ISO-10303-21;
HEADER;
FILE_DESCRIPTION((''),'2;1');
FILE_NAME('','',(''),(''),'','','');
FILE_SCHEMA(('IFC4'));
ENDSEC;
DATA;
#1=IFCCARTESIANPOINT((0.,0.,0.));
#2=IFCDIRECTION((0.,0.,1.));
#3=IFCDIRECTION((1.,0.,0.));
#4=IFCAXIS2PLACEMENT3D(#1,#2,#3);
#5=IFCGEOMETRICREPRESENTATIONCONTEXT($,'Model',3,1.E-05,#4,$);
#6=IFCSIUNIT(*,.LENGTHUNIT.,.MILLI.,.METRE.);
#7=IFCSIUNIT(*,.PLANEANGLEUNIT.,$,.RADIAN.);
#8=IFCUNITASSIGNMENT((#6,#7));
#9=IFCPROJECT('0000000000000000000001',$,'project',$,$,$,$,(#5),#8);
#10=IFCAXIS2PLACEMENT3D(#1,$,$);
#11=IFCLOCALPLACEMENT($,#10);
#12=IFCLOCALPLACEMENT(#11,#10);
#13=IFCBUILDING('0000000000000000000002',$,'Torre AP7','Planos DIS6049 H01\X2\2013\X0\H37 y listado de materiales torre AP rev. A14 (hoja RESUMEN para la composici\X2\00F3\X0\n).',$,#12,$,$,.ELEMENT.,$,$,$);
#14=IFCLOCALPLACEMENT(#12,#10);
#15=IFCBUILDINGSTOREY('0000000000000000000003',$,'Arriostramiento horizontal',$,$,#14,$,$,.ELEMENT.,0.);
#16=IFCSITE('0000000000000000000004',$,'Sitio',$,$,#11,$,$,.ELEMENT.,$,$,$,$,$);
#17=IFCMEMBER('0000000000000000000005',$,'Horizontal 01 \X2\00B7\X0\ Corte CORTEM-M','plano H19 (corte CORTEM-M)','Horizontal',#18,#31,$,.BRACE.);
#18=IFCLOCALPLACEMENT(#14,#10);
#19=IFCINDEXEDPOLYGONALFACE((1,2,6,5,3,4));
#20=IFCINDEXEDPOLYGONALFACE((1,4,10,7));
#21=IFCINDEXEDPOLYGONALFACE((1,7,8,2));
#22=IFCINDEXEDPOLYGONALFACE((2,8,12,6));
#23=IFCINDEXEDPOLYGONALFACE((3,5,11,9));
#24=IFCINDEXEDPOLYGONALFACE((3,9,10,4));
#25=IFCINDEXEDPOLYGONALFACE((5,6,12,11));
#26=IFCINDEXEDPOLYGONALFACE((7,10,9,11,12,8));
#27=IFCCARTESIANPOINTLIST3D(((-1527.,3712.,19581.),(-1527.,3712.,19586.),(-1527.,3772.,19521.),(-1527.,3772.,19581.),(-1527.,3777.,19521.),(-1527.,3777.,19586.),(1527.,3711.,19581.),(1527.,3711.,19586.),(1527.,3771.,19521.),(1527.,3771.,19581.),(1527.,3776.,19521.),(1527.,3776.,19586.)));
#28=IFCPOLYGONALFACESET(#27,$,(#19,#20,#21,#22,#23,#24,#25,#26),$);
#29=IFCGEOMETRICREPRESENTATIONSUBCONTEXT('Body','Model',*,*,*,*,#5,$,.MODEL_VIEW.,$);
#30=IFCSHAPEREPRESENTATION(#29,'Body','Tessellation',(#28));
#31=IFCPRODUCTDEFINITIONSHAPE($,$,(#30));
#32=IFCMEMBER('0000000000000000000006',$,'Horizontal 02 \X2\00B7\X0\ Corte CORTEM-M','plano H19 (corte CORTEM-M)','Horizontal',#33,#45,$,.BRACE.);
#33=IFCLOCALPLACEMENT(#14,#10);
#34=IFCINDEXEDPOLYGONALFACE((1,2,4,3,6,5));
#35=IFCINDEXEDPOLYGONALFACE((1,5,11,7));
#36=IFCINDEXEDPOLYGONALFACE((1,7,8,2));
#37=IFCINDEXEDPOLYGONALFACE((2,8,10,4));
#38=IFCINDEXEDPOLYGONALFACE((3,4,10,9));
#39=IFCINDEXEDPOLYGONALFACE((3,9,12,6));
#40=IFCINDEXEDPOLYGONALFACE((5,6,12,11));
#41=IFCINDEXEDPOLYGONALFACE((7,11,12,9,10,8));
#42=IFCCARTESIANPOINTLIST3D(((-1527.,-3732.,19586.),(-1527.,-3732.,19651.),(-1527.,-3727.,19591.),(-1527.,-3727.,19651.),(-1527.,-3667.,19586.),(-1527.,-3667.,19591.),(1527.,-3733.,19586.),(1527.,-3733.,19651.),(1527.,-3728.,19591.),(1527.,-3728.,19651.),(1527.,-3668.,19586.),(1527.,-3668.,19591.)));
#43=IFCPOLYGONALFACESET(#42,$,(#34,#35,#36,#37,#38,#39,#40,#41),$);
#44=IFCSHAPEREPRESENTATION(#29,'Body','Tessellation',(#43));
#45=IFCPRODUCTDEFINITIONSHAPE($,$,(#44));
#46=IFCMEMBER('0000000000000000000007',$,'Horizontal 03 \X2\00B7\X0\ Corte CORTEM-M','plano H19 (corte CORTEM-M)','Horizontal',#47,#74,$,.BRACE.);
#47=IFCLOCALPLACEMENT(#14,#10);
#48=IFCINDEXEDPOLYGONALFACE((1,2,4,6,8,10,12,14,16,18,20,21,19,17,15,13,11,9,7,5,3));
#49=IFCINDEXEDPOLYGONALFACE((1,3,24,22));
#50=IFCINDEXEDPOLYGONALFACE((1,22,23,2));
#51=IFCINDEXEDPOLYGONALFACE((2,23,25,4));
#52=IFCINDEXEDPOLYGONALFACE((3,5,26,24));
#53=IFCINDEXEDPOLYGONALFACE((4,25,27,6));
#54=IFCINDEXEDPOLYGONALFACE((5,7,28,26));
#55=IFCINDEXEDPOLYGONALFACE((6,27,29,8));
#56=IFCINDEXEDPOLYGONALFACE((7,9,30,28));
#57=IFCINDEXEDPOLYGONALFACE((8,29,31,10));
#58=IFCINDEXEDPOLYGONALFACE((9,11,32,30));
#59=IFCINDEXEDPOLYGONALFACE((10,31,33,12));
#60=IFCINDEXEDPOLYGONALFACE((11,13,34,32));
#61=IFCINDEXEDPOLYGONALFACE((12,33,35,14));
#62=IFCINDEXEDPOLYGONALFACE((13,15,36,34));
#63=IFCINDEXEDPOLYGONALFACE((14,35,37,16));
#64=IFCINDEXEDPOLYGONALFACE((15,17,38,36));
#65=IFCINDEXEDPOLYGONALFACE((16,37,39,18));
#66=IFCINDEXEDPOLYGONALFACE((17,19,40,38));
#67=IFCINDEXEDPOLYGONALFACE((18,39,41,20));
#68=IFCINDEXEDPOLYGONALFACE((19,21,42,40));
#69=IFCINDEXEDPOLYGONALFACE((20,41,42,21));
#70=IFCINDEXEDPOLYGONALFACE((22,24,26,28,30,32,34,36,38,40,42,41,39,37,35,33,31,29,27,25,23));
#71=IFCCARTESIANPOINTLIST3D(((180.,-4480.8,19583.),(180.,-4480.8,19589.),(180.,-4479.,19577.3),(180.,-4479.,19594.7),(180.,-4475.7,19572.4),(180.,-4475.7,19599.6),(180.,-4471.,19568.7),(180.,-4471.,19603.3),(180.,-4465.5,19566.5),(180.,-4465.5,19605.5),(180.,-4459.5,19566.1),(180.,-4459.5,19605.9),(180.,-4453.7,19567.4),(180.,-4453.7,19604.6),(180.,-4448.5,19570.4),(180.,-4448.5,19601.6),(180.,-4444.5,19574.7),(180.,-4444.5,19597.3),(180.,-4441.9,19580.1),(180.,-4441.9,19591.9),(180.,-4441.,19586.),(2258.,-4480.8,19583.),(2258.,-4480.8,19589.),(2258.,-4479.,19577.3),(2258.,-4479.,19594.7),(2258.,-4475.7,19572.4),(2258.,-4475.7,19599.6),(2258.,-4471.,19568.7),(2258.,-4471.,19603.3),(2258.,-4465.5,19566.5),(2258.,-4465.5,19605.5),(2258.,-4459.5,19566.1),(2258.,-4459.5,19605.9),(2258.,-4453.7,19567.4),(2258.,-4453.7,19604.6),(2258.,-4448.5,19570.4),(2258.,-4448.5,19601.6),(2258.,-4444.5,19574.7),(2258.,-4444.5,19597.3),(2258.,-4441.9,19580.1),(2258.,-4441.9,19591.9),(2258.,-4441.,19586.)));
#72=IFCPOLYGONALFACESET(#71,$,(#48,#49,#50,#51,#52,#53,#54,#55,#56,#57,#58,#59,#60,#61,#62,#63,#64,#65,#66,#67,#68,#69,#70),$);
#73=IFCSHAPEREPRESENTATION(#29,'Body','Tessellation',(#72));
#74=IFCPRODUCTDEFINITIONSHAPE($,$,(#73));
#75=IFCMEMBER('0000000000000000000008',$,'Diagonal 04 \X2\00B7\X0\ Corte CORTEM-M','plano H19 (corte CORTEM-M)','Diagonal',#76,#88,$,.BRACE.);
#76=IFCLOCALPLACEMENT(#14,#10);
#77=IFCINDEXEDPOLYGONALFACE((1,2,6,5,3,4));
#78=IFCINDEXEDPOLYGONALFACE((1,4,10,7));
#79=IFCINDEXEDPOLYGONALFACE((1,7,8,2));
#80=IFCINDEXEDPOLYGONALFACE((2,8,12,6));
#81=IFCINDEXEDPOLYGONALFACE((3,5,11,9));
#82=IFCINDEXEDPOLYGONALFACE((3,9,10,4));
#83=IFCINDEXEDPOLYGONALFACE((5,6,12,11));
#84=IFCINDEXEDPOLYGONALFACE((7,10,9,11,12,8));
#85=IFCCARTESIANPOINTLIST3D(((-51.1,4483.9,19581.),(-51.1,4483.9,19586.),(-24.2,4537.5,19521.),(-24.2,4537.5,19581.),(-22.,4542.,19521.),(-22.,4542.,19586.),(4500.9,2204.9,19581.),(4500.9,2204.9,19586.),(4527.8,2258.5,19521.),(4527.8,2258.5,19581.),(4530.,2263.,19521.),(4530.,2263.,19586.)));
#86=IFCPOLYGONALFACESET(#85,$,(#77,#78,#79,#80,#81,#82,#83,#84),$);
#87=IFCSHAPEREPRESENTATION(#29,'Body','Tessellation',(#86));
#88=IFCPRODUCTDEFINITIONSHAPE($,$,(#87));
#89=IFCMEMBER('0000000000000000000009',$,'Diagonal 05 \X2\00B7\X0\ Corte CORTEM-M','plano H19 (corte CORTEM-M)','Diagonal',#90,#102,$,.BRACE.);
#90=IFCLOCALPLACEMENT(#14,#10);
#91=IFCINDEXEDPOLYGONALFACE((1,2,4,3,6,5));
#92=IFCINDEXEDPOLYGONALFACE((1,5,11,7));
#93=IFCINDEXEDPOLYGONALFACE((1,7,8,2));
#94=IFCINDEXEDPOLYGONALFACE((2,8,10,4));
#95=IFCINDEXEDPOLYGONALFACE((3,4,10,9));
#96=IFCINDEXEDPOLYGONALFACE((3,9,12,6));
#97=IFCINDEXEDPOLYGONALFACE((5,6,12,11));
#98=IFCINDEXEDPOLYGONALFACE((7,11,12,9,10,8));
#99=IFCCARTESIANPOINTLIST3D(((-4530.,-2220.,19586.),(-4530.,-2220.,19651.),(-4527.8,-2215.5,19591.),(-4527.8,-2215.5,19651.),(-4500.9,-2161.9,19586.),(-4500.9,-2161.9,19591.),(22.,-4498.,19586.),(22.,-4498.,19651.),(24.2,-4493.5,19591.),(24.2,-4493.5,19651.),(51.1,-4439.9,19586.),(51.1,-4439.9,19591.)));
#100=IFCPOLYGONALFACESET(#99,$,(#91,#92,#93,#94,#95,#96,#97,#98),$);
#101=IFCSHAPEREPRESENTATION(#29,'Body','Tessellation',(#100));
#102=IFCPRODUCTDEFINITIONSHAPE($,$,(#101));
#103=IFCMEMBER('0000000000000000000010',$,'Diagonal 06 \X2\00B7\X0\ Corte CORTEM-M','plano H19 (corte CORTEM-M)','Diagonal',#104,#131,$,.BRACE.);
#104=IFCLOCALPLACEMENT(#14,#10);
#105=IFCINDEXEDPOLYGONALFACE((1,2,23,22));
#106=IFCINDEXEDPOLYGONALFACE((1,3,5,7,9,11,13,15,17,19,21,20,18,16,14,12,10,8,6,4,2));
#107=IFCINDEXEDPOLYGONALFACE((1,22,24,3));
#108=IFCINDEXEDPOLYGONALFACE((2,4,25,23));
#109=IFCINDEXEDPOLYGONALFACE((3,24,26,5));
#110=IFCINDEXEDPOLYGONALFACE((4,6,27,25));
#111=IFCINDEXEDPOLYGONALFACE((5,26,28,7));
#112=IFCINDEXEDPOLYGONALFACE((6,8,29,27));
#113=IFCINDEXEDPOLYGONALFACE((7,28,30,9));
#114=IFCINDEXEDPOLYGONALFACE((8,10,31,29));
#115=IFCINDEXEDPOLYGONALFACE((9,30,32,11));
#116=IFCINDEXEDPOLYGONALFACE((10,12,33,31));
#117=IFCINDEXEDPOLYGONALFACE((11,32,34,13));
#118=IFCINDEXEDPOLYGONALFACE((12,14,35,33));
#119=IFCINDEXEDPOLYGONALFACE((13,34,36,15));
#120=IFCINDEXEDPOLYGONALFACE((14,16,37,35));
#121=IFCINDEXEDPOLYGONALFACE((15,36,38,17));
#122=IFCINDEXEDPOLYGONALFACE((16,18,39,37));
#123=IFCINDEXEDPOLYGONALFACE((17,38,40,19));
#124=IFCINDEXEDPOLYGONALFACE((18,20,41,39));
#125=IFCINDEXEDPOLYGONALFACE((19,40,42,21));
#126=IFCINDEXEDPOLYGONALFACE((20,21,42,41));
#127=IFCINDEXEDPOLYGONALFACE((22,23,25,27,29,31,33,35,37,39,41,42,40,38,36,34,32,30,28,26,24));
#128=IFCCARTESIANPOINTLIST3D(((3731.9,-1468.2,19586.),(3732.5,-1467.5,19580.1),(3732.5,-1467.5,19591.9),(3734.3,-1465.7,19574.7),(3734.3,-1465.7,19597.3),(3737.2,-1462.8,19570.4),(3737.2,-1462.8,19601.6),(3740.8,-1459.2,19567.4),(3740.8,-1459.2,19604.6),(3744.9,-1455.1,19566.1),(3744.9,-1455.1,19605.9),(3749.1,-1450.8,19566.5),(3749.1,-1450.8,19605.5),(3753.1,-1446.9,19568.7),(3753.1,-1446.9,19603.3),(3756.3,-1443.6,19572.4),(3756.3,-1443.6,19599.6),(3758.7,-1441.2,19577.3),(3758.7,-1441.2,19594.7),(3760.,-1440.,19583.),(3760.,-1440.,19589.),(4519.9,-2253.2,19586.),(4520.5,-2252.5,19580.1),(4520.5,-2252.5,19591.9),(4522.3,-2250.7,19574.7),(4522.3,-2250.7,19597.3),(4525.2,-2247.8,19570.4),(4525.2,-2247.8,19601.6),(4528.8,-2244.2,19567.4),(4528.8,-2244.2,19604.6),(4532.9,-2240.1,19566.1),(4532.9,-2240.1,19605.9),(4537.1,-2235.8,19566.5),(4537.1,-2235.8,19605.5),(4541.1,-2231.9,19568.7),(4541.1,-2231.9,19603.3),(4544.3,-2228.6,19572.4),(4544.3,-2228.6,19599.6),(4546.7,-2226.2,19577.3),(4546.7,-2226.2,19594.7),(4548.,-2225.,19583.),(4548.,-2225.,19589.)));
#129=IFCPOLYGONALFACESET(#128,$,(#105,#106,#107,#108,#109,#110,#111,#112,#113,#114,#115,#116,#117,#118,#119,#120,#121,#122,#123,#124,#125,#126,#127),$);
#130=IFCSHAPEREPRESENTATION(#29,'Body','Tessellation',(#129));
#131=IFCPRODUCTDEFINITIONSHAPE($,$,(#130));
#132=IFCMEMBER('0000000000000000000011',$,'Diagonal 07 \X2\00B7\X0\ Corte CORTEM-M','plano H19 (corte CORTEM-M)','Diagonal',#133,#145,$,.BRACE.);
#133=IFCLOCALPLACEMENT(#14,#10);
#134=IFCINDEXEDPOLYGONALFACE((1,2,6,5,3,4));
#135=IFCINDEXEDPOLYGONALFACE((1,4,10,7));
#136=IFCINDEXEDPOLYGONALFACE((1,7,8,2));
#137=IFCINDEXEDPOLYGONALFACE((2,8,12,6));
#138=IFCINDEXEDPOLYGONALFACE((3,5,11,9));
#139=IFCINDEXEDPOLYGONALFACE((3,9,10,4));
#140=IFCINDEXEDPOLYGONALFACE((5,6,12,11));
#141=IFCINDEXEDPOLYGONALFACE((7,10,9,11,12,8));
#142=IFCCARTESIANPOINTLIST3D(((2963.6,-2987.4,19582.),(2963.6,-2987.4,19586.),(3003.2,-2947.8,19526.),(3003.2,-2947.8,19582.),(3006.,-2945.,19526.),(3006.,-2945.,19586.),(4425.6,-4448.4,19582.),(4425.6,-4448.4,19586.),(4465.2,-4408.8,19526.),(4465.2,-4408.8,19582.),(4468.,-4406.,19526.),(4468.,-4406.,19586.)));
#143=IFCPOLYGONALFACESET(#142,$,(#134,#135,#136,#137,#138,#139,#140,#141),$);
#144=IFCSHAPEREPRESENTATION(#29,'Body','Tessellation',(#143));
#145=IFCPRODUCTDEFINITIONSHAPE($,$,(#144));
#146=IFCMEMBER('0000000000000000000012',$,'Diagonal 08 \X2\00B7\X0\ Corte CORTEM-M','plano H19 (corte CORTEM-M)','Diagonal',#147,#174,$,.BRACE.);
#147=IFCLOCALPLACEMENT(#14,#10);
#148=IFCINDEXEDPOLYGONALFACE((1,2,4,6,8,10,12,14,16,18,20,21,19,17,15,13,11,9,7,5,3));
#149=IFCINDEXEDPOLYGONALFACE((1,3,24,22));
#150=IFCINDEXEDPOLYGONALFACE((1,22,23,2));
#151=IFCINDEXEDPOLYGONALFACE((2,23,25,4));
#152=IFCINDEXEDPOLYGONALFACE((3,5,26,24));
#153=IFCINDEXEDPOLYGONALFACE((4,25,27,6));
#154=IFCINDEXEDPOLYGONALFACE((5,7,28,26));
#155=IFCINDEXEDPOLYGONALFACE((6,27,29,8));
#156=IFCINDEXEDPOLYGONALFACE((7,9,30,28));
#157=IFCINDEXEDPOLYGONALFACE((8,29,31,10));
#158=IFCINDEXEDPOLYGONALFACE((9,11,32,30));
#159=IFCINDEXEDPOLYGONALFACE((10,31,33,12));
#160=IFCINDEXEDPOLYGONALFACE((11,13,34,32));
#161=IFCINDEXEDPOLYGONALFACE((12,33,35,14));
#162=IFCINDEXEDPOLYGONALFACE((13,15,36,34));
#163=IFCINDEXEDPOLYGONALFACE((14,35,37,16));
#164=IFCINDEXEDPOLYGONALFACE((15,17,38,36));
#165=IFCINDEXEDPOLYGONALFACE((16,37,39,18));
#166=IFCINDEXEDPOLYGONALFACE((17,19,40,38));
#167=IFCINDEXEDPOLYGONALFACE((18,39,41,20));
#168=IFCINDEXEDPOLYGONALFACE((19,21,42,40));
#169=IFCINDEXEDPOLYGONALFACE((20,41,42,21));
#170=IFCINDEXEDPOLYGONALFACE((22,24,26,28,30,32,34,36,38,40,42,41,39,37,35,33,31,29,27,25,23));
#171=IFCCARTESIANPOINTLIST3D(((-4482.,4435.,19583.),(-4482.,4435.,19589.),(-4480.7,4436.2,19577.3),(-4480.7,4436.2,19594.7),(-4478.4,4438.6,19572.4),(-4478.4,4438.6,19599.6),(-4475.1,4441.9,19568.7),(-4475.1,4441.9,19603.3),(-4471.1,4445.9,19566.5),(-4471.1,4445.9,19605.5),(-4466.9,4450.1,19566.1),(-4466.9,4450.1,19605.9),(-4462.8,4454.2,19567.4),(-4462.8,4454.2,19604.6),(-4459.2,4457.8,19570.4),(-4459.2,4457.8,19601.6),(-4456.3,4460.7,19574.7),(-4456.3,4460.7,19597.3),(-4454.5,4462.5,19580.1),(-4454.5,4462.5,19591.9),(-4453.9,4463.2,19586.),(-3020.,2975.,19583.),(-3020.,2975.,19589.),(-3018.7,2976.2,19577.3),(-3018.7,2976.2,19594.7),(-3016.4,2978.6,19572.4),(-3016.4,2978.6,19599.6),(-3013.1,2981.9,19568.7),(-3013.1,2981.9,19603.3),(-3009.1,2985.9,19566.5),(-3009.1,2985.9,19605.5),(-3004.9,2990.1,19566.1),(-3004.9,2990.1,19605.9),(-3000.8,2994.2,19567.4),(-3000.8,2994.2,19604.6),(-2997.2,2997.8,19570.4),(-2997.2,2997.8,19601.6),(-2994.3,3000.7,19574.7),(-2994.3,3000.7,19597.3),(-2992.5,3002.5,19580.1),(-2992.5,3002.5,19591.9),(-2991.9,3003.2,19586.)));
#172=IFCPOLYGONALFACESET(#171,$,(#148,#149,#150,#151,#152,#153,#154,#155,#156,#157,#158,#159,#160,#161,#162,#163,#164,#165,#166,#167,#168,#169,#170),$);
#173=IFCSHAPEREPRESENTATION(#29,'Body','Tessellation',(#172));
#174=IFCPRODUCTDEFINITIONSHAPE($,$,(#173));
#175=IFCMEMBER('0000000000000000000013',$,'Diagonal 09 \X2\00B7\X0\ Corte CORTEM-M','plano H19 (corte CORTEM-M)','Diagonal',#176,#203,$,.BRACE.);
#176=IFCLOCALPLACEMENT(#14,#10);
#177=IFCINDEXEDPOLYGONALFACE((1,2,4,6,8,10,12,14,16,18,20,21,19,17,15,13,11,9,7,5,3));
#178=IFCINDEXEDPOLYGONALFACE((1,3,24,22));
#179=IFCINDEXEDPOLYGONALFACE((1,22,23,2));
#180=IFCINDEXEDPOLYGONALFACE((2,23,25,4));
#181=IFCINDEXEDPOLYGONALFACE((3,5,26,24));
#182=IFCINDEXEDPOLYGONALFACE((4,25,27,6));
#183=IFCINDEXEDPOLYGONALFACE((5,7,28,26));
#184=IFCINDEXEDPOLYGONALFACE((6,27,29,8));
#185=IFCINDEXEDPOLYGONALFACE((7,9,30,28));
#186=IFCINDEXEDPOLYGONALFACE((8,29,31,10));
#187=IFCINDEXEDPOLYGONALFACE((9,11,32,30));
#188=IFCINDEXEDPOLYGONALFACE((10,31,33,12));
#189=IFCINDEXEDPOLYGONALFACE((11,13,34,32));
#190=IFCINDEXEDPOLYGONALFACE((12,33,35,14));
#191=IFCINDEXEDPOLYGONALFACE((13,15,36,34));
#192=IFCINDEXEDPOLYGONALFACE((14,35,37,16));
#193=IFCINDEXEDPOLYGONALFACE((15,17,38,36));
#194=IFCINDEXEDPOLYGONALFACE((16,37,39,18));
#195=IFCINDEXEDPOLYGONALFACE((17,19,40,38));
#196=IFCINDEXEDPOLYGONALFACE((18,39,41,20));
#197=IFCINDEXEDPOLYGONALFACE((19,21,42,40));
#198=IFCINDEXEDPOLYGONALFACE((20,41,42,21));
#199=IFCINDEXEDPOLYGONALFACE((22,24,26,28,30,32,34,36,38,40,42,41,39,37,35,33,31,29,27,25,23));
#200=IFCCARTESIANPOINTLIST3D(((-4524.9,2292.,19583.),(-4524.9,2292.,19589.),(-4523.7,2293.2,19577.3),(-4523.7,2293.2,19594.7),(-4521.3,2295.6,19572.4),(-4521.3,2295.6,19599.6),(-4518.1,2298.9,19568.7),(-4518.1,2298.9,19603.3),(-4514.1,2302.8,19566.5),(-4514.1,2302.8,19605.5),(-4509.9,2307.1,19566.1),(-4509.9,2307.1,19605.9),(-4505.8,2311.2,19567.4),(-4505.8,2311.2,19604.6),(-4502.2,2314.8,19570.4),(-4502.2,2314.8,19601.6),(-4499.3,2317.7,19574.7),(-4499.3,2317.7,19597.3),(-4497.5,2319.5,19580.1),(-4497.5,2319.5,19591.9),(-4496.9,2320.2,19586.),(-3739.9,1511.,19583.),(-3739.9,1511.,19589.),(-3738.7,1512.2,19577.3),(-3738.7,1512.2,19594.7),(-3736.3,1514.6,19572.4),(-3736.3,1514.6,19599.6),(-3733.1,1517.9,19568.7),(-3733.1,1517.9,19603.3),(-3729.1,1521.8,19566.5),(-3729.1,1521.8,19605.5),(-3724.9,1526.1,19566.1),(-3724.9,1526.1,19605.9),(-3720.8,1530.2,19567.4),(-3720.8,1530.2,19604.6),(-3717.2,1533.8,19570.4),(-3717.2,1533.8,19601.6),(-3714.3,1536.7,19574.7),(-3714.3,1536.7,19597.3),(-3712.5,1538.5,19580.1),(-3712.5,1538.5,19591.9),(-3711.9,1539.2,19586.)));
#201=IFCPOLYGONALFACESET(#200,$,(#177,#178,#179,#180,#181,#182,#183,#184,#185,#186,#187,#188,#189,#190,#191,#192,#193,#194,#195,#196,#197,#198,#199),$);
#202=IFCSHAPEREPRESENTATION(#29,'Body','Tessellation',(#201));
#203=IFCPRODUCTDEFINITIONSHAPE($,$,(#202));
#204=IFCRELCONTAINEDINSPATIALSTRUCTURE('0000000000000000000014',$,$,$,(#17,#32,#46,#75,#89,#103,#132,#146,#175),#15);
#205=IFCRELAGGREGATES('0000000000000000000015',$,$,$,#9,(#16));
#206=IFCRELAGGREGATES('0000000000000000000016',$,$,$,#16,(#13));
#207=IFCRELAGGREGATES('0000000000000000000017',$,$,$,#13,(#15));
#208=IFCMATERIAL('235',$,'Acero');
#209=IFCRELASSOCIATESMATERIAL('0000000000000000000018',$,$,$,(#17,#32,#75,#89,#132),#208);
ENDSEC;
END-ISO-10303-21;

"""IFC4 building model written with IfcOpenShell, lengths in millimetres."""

from ifc_helpers import new_model, si_unit, frame, frame_2d, origin, origin_with_axes, place, context, subcontext, project, spatial, circle, l_section, extrude, material, element, save


model = new_model("IFC4")

# Units and contexts
model_context = context("Model", 3, precision=1e-05, world=origin_with_axes())
body_context = subcontext(model_context, "Body", "Model", "MODEL_VIEW")
ifc_project = project(units=[si_unit("LENGTHUNIT", "METRE", prefix="MILLI"), si_unit("PLANEANGLEUNIT", "RADIAN")], contexts=[model_context])

# Site, building, storey
site_placement = place(None, origin())
site = spatial("IfcSite", under=ifc_project, at=site_placement, Name="Sitio", CompositionType="ELEMENT")
building_placement = place(site_placement, origin())
building = spatial("IfcBuilding", under=site, at=building_placement, Name="Torre AP7", Description="Planos DIS6049 H01–H37 y listado de materiales torre AP rev. A14 (hoja RESUMEN para la composición).", CompositionType="ELEMENT")
storey_placement = place(building_placement, origin())
storey = spatial("IfcBuildingStorey", under=building, at=storey_placement, Name="Arriostramiento horizontal", CompositionType="ELEMENT", Elevation=0.0)

# Members
ifc_material = material(Name="235", Category="Acero")
for number, where, z_axis, x_axis, name in (
    (1, (-1527.0, 3777.0, 19586.0), (1.0, -0.000327, 0.0), (-0.000327, -1.0, 0.0), "Horizontal 01 · Corte CORTEM-M"),
    (2, (-1527.0, -3732.0, 19586.0), (1.0, -0.000327, 0.0), (0.000327, 1.0, 0.0), "Horizontal 02 · Corte CORTEM-M"),
):
    element("IfcMember", number, at=place(storey_placement, frame(where, z_axis=z_axis, x_axis=x_axis)), inside=storey, material=ifc_material, Name=name, Description="plano H19 (corte CORTEM-M)", ObjectType="Horizontal", PredefinedType="BRACE", context=body_context, shape_type="SweptSolid", body=[
        extrude(l_section(Depth=65.0, Width=65.0, Thickness=5.0, at=frame_2d((32.5, 32.5))), None, (0.0, 0.0, 1.0), 3054.0),
    ])
member_1_placement = place(storey_placement, frame((180.0, -4461.0, 19586.0), z_axis=(1.0, 0.0, 0.0), x_axis=(0.0, 1.0, 0.0)))
element("IfcMember", 3, at=member_1_placement, inside=storey, Name="Horizontal 03 · Corte CORTEM-M", Description="plano H19 (corte CORTEM-M)", ObjectType="Horizontal", PredefinedType="BRACE", context=body_context, shape_type="SweptSolid", body=[
    extrude(circle(Radius=20.0), None, (0.0, 0.0, 1.0), 2078.0),
])
member_2_placement = place(storey_placement, frame((-22.0, 4542.0, 19586.0), z_axis=(0.894191, -0.447685, 0.0), x_axis=(-0.447685, -0.894191, 0.0)))
element("IfcMember", 4, at=member_2_placement, inside=storey, material=ifc_material, Name="Diagonal 04 · Corte CORTEM-M", Description="plano H19 (corte CORTEM-M)", ObjectType="Diagonal", PredefinedType="BRACE", context=body_context, shape_type="SweptSolid", body=[
    extrude(l_section(Depth=65.0, Width=65.0, Thickness=5.0, at=frame_2d((32.5, 32.5))), None, (0.0, 0.0, 1.0), 5090.6),
])
member_3_placement = place(storey_placement, frame((-4530.0, -2220.0, 19586.0), z_axis=(0.89427, -0.447528, 0.0), x_axis=(0.447528, 0.89427, 0.0)))
element("IfcMember", 5, at=member_3_placement, inside=storey, material=ifc_material, Name="Diagonal 05 · Corte CORTEM-M", Description="plano H19 (corte CORTEM-M)", ObjectType="Diagonal", PredefinedType="BRACE", context=body_context, shape_type="SweptSolid", body=[
    extrude(l_section(Depth=65.0, Width=65.0, Thickness=5.0, at=frame_2d((32.5, 32.5))), None, (0.0, 0.0, 1.0), 5090.2),
])
member_4_placement = place(storey_placement, frame((3746.0, -1454.0, 19586.0), z_axis=(0.708454, -0.705757, 0.0), x_axis=(-0.705757, -0.708454, 0.0)))
element("IfcMember", 6, at=member_4_placement, inside=storey, Name="Diagonal 06 · Corte CORTEM-M", Description="plano H19 (corte CORTEM-M)", ObjectType="Diagonal", PredefinedType="BRACE", context=body_context, shape_type="SweptSolid", body=[
    extrude(circle(Radius=20.0), None, (0.0, 0.0, 1.0), 1112.3),
])
member_5_placement = place(storey_placement, frame((3006.0, -2945.0, 19586.0), z_axis=(0.707349, -0.706865, 0.0), x_axis=(-0.706865, -0.707349, 0.0)))
element("IfcMember", 7, at=member_5_placement, inside=storey, material=ifc_material, Name="Diagonal 07 · Corte CORTEM-M", Description="plano H19 (corte CORTEM-M)", ObjectType="Diagonal", PredefinedType="BRACE", context=body_context, shape_type="SweptSolid", body=[
    extrude(l_section(Depth=60.0, Width=60.0, Thickness=4.0, at=frame_2d((30.0, 30.0))), None, (0.0, 0.0, 1.0), 2066.9),
])
member_6_placement = place(storey_placement, frame((-4468.0, 4449.0, 19586.0), z_axis=(0.707591, -0.706623, 0.0), x_axis=(0.706623, 0.707591, 0.0)))
element("IfcMember", 8, at=member_6_placement, inside=storey, Name="Diagonal 08 · Corte CORTEM-M", Description="plano H19 (corte CORTEM-M)", ObjectType="Diagonal", PredefinedType="BRACE", context=body_context, shape_type="SweptSolid", body=[
    extrude(circle(Radius=20.0), None, (0.0, 0.0, 1.0), 2066.2),
])
member_7_placement = place(storey_placement, frame((-4511.0, 2306.0, 19586.0), z_axis=(0.708911, -0.705298, 0.0), x_axis=(0.705298, 0.708911, 0.0)))
element("IfcMember", 9, at=member_7_placement, inside=storey, Name="Diagonal 09 · Corte CORTEM-M", Description="plano H19 (corte CORTEM-M)", ObjectType="Diagonal", PredefinedType="BRACE", context=body_context, shape_type="SweptSolid", body=[
    extrude(circle(Radius=20.0), None, (0.0, 0.0, 1.0), 1107.3),
])

save(model, "model.ifc")
